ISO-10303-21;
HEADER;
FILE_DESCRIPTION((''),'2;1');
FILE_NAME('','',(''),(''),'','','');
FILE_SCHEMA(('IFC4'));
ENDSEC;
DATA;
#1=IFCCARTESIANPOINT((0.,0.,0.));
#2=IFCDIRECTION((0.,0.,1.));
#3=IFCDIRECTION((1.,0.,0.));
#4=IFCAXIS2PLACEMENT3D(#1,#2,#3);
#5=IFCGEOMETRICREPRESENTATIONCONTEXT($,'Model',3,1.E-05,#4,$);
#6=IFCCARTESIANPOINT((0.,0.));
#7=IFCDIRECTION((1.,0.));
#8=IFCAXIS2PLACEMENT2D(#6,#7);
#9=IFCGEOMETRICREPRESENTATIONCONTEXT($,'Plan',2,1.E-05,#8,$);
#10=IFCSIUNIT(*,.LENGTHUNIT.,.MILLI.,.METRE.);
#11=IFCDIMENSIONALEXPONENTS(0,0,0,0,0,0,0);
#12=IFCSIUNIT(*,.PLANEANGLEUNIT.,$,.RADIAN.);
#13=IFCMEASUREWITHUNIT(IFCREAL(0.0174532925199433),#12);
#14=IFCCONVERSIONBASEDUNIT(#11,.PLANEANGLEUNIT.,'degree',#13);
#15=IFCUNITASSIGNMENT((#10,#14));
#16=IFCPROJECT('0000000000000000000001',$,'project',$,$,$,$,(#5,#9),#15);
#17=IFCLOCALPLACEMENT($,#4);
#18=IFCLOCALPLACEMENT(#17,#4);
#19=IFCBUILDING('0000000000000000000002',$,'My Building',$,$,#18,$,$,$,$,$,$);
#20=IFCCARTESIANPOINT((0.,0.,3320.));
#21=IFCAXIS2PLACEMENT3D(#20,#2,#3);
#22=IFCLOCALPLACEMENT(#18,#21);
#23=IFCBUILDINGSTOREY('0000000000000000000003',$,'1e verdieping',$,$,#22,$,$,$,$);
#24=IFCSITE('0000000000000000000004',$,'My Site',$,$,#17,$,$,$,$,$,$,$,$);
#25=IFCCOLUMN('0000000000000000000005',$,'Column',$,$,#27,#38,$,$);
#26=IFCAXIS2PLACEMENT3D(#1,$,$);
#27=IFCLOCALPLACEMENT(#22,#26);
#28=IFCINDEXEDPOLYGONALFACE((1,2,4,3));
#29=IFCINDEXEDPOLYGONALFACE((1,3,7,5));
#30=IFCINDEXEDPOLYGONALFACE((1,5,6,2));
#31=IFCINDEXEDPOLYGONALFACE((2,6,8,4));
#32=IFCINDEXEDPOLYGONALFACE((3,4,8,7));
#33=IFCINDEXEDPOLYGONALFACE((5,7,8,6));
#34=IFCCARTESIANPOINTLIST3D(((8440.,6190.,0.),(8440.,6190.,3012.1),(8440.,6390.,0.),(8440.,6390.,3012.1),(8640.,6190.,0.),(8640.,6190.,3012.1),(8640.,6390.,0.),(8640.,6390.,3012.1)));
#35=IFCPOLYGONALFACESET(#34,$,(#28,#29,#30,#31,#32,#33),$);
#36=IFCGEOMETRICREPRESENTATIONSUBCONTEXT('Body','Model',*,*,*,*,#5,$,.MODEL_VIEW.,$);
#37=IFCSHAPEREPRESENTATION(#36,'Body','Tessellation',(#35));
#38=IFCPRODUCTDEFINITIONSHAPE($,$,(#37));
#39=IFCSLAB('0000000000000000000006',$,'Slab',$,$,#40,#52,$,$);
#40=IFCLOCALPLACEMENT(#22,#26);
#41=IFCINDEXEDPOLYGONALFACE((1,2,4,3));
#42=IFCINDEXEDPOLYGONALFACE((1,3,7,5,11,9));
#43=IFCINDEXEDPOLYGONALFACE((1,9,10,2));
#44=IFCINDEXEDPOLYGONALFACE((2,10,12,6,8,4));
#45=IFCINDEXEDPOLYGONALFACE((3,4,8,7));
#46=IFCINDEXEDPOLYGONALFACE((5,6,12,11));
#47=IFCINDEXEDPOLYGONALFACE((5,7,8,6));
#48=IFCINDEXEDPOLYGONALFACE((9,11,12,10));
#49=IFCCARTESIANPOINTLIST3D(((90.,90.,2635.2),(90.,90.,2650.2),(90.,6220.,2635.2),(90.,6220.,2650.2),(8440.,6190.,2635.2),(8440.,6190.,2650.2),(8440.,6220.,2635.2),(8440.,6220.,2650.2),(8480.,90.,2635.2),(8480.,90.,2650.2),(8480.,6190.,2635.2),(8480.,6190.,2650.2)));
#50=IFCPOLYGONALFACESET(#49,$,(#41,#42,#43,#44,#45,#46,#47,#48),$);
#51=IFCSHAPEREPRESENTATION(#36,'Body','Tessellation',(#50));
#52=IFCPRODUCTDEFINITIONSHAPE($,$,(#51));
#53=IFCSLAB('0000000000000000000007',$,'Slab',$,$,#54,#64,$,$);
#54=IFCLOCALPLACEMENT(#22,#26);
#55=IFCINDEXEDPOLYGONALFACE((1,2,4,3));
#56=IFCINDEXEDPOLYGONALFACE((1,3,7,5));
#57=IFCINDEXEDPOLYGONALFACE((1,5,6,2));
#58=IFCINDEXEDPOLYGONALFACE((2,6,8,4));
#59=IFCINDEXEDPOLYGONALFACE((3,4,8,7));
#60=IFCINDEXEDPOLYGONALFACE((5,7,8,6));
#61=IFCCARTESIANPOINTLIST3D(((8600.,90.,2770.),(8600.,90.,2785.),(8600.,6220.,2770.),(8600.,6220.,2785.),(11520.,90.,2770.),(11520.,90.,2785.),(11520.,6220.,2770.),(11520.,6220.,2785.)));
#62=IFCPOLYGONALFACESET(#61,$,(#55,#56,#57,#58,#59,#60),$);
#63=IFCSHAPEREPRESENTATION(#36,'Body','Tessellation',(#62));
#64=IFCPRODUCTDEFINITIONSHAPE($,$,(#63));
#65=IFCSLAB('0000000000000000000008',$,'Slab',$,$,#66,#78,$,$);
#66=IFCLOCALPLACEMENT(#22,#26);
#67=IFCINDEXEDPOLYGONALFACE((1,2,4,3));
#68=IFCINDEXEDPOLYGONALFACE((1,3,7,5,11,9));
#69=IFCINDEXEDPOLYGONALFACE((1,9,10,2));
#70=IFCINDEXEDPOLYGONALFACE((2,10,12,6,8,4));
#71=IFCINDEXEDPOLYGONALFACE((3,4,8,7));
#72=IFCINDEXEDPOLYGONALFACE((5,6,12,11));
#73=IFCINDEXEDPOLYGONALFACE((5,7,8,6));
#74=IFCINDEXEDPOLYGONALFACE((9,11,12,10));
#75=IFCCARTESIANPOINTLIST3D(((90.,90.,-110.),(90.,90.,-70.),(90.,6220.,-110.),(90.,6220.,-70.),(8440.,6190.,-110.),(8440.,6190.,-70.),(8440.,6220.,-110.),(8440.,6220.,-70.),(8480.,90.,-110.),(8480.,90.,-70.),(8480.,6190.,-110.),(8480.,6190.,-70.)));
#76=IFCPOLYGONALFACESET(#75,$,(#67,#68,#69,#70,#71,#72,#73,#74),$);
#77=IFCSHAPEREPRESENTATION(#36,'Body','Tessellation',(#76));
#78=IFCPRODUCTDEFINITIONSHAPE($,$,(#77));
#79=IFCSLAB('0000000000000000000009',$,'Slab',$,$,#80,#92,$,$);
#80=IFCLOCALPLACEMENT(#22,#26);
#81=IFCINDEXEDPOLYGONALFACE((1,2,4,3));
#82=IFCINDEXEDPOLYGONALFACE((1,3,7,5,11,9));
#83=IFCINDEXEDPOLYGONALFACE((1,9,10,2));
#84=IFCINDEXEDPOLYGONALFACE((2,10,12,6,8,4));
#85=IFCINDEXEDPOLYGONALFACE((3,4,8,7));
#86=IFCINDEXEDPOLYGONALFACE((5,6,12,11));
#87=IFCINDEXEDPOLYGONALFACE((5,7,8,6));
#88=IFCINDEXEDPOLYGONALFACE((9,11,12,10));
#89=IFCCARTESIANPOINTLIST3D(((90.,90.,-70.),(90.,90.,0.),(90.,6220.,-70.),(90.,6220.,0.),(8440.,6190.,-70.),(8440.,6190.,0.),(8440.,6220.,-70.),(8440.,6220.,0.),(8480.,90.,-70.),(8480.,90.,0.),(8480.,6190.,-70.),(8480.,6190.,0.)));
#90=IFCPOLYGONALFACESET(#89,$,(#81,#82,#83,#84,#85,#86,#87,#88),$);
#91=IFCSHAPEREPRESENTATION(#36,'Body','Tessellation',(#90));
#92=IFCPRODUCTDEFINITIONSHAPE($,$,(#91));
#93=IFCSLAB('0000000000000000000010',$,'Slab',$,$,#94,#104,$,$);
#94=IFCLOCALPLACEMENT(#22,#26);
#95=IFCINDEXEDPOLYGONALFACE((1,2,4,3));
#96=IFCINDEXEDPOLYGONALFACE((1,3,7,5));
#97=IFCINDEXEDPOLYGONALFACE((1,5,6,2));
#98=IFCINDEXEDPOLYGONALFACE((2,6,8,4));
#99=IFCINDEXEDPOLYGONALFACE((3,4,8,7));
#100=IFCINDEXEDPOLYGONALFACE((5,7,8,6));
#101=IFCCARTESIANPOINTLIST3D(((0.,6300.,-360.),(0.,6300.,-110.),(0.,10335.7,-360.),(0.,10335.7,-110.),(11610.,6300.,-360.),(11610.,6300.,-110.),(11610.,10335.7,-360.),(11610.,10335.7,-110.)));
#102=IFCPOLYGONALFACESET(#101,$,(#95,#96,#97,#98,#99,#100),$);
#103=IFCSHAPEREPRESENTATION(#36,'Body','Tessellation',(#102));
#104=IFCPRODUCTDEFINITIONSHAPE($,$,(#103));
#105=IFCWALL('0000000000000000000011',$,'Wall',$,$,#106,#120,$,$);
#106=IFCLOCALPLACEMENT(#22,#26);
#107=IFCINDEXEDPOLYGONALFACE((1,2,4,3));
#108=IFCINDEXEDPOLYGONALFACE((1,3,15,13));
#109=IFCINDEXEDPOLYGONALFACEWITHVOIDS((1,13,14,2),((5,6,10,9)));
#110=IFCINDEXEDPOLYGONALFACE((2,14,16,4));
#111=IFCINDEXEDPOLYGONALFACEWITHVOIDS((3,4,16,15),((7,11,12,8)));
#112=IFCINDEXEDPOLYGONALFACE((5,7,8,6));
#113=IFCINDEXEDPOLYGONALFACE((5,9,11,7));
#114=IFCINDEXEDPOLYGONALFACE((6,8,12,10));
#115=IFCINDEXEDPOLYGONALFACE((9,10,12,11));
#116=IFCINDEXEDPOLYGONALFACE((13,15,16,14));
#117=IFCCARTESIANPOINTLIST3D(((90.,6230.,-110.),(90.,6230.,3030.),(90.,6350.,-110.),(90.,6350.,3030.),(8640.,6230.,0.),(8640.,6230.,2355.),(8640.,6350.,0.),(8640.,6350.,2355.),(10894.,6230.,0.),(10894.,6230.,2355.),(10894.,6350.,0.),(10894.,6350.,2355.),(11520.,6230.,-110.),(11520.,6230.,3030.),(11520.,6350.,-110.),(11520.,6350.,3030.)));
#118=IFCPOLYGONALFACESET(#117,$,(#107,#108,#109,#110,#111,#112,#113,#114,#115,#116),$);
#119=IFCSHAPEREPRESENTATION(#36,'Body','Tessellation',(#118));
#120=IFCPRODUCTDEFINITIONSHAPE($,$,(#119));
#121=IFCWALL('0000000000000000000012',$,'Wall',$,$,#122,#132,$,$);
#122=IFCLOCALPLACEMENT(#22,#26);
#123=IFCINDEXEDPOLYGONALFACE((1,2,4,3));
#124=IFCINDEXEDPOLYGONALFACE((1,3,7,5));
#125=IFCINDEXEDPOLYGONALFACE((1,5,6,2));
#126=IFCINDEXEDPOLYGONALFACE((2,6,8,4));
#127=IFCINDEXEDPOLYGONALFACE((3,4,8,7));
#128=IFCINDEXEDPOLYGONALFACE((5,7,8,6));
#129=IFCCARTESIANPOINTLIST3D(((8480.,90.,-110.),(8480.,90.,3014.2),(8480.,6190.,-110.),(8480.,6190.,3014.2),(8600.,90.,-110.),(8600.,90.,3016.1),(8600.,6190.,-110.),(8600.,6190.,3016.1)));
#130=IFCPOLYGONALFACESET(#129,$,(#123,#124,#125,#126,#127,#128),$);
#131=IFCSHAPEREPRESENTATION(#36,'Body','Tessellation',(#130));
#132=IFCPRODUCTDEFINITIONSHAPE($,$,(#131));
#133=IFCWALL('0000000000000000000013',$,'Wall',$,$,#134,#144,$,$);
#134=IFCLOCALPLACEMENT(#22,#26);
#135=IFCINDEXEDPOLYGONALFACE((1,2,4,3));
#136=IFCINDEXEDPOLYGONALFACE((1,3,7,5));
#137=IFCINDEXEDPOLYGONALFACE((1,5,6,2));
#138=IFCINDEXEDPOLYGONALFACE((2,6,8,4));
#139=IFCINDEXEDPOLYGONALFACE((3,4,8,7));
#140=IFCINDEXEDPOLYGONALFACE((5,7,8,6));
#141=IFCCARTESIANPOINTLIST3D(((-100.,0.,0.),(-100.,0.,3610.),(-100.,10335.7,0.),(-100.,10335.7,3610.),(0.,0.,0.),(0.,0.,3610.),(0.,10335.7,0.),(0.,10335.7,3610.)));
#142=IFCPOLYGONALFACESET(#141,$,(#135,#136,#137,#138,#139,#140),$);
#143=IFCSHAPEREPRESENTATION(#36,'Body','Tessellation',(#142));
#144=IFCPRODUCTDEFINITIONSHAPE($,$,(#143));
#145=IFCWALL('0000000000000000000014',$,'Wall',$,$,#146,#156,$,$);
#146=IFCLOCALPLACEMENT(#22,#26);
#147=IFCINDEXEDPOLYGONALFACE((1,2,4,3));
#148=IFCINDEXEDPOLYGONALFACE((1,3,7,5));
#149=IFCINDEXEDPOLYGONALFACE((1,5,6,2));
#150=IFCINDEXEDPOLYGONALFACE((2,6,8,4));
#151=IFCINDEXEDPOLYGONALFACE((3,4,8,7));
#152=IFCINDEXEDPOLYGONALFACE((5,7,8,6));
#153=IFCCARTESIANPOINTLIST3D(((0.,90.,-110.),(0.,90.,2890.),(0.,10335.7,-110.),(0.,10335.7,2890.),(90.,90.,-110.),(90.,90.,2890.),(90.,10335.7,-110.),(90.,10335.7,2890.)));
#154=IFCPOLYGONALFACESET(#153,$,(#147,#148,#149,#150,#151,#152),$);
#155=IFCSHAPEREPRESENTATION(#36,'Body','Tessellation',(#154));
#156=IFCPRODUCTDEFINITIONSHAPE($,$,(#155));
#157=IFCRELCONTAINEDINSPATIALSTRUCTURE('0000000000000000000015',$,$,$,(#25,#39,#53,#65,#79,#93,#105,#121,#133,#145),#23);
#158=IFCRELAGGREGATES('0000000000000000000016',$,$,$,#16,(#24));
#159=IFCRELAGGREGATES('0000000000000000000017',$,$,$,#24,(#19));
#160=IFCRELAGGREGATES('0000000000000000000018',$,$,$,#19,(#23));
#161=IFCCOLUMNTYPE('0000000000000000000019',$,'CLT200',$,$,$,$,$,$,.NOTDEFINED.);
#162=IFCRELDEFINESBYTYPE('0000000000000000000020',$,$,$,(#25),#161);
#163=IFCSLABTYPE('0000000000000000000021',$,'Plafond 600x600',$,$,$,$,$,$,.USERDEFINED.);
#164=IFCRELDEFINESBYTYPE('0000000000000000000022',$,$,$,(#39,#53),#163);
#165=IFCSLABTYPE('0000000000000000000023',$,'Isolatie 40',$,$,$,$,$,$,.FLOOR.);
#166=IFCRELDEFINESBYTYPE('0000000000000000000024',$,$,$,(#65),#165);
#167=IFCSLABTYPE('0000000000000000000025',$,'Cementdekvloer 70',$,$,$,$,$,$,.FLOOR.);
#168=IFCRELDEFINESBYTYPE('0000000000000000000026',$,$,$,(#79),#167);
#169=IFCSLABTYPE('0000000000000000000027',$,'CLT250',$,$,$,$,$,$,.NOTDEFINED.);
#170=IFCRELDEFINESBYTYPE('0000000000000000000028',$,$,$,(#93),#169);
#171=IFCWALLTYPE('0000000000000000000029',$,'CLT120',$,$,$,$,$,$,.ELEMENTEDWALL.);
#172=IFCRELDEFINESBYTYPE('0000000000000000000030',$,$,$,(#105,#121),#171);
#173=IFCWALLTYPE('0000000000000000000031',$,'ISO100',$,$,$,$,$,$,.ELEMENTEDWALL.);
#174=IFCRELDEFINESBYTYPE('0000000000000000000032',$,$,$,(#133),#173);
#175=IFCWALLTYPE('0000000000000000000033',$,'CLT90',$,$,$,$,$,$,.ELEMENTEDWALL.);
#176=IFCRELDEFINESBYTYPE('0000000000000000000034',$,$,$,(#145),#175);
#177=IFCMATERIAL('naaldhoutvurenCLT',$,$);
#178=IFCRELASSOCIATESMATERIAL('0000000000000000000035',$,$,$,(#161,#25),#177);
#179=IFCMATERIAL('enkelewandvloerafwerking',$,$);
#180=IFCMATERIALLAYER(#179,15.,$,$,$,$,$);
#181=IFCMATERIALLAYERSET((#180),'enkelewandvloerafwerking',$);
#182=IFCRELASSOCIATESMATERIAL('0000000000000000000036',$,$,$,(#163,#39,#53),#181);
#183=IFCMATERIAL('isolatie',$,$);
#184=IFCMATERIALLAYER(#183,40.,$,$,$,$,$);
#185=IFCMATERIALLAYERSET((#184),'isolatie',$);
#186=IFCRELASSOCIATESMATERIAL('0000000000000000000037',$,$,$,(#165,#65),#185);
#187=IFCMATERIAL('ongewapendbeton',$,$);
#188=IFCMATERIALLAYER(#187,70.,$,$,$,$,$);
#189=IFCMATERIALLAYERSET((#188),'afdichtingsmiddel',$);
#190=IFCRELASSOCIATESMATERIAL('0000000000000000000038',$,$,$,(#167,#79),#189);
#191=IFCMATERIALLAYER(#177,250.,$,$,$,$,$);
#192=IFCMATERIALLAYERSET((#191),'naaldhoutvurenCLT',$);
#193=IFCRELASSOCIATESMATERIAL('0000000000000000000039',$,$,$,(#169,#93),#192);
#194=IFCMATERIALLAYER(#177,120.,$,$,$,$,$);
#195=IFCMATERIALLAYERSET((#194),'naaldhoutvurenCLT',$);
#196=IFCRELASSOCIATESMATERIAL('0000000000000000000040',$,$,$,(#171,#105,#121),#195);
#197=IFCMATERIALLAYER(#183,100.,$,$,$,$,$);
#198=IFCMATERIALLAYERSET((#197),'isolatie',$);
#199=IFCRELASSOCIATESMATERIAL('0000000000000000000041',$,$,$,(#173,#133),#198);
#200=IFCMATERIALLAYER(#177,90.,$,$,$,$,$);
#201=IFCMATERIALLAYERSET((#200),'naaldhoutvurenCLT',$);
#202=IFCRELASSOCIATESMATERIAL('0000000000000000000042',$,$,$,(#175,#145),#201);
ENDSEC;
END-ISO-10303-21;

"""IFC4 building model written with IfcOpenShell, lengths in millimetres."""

from ifc_helpers import new_model, entity, si_unit, converted_unit, frame, origin_with_axes, origin_2d_with_axis, place, context, subcontext, project, spatial, line, indexed_curve, rectangle, outline, extrude, clip, halfspace, source, transform, mapped, material, layer, layer_set, layer_usage, material_profile, profile_set, profile_usage, type_object, element, save


model = new_model("IFC4")

# Units and contexts
model_context = context("Model", 3, precision=1e-05, world=origin_with_axes())
plan_context = context("Plan", 2, precision=1e-05, world=origin_2d_with_axis())
body_context = subcontext(model_context, "Body", "Model", "MODEL_VIEW")
ifc_project = project(units=[si_unit("LENGTHUNIT", "METRE", prefix="MILLI"), converted_unit("PLANEANGLEUNIT", "degree", entity("IfcReal", 0.0174532925199433), si_unit("PLANEANGLEUNIT", "RADIAN"), dimensions=[0, 0, 0, 0, 0, 0, 0])], contexts=[model_context, plan_context])

# Site, building, storey
site_placement = place(None, origin_with_axes())
site = spatial("IfcSite", under=ifc_project, at=site_placement, Name="My Site")
building_placement = place(site_placement, origin_with_axes())
building = spatial("IfcBuilding", under=site, at=building_placement, Name="My Building")
storey_placement = place(building_placement, frame((0.0, 0.0, 3320.0), z_axis=(0.0, 0.0, 1.0), x_axis=(1.0, 0.0, 0.0)))
storey = spatial("IfcBuildingStorey", under=building, at=storey_placement, Name="1e verdieping")

# Column
ifc_material_1 = material(Name="naaldhoutvurenCLT")
ifc_material_profile = material_profile(ifc_material_1, rectangle(XDim=200.0, YDim=200.0))
ifc_profile_set = profile_set([ifc_material_profile], Name="naaldhoutvurenCLT")
ifc_profile_usage = profile_usage(ifc_profile_set, cardinal=5)
column_type = type_object("IfcColumnType", Name="CLT200", PredefinedType="NOTDEFINED", material=ifc_profile_set)
column_placement = place(storey_placement, frame((8540.0, 6290.0, 0.0), z_axis=(0.0, 0.0, 1.0), x_axis=(1.0, 0.0, 0.0)))
element("IfcColumn", 1, at=column_placement, inside=storey, type_object=column_type, material=ifc_profile_usage, Name="Column", context=body_context, shape_type="SweptSolid", body=[
    extrude(rectangle(XDim=200.0, YDim=200.0), origin_with_axes(), (0.0, 0.0, 1.0), 3012.1),
])

# Slabs
ifc_material_2 = material(Name="enkelewandvloerafwerking")
ifc_layer_1 = layer(ifc_material_2, 15.0)
ifc_layer_set_1 = layer_set([ifc_layer_1], Name="enkelewandvloerafwerking")
ifc_layer_usage_1 = layer_usage(ifc_layer_set_1, "AXIS3", "POSITIVE", 0.0)
slab_type_1 = type_object("IfcSlabType", Name="Plafond 600x600", PredefinedType="USERDEFINED", material=ifc_layer_set_1)
slab_1_placement = place(storey_placement, frame((90.0, 90.0, 2635.2), z_axis=(0.0, 0.0, 1.0), x_axis=(1.0, 0.0, 0.0)))
element("IfcSlab", 2, at=slab_1_placement, inside=storey, type_object=slab_type_1, material=ifc_layer_usage_1, Name="Slab", context=body_context, shape_type="SweptSolid", body=[
    extrude(outline(indexed_curve([(0.0, 0.0), (8390.0, 0.0), (8350.0, 6130.0), (0.0, 6130.0), (8350.0, 6100.0), (8390.0, 6100.0)], segments=[line(3, 5), line(5, 6), line(6, 2), line(2, 1), line(1, 4), line(4, 3)], self_intersect=False)), None, (0.0, 0.0, 1.0), 15.0),
])
ifc_layer_usage_2 = layer_usage(ifc_layer_set_1, "AXIS3", "POSITIVE", 0.0)
slab_2_placement = place(storey_placement, frame((8600.0, 6220.0, 2770.0), z_axis=(0.0, 0.0, 1.0), x_axis=(1.0, 0.0, 0.0)))
element("IfcSlab", 3, at=slab_2_placement, inside=storey, type_object=slab_type_1, material=ifc_layer_usage_2, Name="Slab", context=body_context, shape_type="SweptSolid", body=[
    extrude(outline(indexed_curve([(0.0, -6130.0), (2920.0, -6130.0), (2920.0, 0.0), (0.0, 0.0)], segments=[line(4, 1), line(1, 2), line(2, 3), line(3, 4)], self_intersect=False)), None, (0.0, 0.0, 1.0), 15.0),
])
ifc_material_3 = material(Name="isolatie")
ifc_layer_2 = layer(ifc_material_3, 40.0)
ifc_layer_set_2 = layer_set([ifc_layer_2], Name="isolatie")
slab_type_2 = type_object("IfcSlabType", Name="Isolatie 40", PredefinedType="FLOOR", material=ifc_layer_set_2)
ifc_layer_usage_3 = layer_usage(ifc_layer_set_2, "AXIS3", "POSITIVE", 0.0)
slab_3_placement = place(storey_placement, frame((90.0, 90.0, -110.0), z_axis=(0.0, 0.0, 1.0), x_axis=(1.0, 0.0, 0.0)))
element("IfcSlab", 4, at=slab_3_placement, inside=storey, type_object=slab_type_2, material=ifc_layer_usage_3, Name="Slab", context=body_context, shape_type="SweptSolid", body=[
    extrude(outline(indexed_curve([(0.0, 0.0), (8390.0, 0.0), (8350.0, 6130.0), (0.0, 6130.0), (8350.0, 6100.0), (8390.0, 6100.0)], segments=[line(2, 1), line(1, 4), line(4, 3), line(3, 5), line(5, 6), line(6, 2)], self_intersect=False)), None, (0.0, 0.0, 1.0), 40.0),
])
ifc_material_4 = material(Name="ongewapendbeton")
ifc_layer_3 = layer(ifc_material_4, 70.0)
ifc_layer_set_3 = layer_set([ifc_layer_3], Name="afdichtingsmiddel")
slab_type_3 = type_object("IfcSlabType", Name="Cementdekvloer 70", PredefinedType="FLOOR", material=ifc_layer_set_3)
ifc_layer_usage_4 = layer_usage(ifc_layer_set_3, "AXIS3", "POSITIVE", 0.0)
slab_4_placement = place(storey_placement, frame((90.0, 90.0, -70.0), z_axis=(0.0, 0.0, 1.0), x_axis=(1.0, 0.0, 0.0)))
element("IfcSlab", 5, at=slab_4_placement, inside=storey, type_object=slab_type_3, material=ifc_layer_usage_4, Name="Slab", context=body_context, shape_type="SweptSolid", body=[
    extrude(outline(indexed_curve([(0.0, 0.0), (8390.0, 0.0), (8350.0, 6130.0), (0.0, 6130.0), (8350.0, 6100.0), (8390.0, 6100.0)], segments=[line(2, 1), line(1, 4), line(4, 3), line(3, 5), line(5, 6), line(6, 2)], self_intersect=False)), None, (0.0, 0.0, 1.0), 70.0),
])
ifc_layer_4 = layer(ifc_material_1, 250.0)
ifc_layer_set_4 = layer_set([ifc_layer_4], Name="naaldhoutvurenCLT")
ifc_layer_usage_5 = layer_usage(ifc_layer_set_4, "AXIS3", "POSITIVE", 0.0)
slab_type_4 = type_object("IfcSlabType", Name="CLT250", PredefinedType="NOTDEFINED", material=ifc_layer_set_4)
slab_5_placement = place(storey_placement, frame((0.0, 6300.0, -360.0), z_axis=(0.0, 0.0, 1.0), x_axis=(1.0, 0.0, 0.0)))
element("IfcSlab", 6, at=slab_5_placement, inside=storey, type_object=slab_type_4, material=ifc_layer_usage_5, Name="Slab", context=body_context, shape_type="SweptSolid", body=[
    extrude(outline(indexed_curve([(11610.0, 0.0), (0.0, 0.0), (0.0, 4035.7), (11610.0, 4035.7)], segments=[line(4, 1), line(1, 2), line(2, 3), line(3, 4)], self_intersect=False)), None, (0.0, 0.0, 1.0), 250.0),
])

# Wall, opening
ifc_layer_5 = layer(ifc_material_1, 120.0)
ifc_layer_set_5 = layer_set([ifc_layer_5], Name="naaldhoutvurenCLT")
ifc_layer_usage_6 = layer_usage(ifc_layer_set_5, "AXIS2", "POSITIVE", 0.0)
wall_type_1 = type_object("IfcWallType", Name="CLT120", PredefinedType="ELEMENTEDWALL", material=ifc_layer_set_5)
wall_1_placement = place(storey_placement, frame((90.0, 6230.0, -110.0), z_axis=(0.0, 0.0, 1.0), x_axis=(1.0, -0.000001, 0.0)))
wall_1 = element("IfcWall", 7, at=wall_1_placement, inside=storey, type_object=wall_type_1, material=ifc_layer_usage_6, Name="Wall", context=body_context, shape_type="SweptSolid", body=[
    extrude(outline(indexed_curve([(0.0, 0.0), (0.0, 120.0), (11430.0, 120.0), (11430.0, 0.0), (0.0, 0.0)], self_intersect=False)), origin_with_axes(), (0.0, 0.0, 1.0), 3140.0),
])
shared_shape_1 = source(origin_with_axes(), body_context, "Body", "SweptSolid", [
    extrude(outline(indexed_curve([(0.0, 0.0), (2254.0, 0.0), (2254.0, 2355.0), (0.0, 2355.0)], segments=[line(1, 2, 3, 4, 1)])), frame((0.0, -600.0, 0.0), z_axis=(0.0, -1.0, 0.0), x_axis=(1.0, 0.0, 0.0)), (0.0, 0.0, -1.0), 1200.0),
])
opening_1_placement = place(wall_1_placement, frame((8550.0, 31.8, 110.0), z_axis=(0.0, 0.0, 1.0), x_axis=(1.0, 0.0, 0.0)))
element("IfcOpeningElement", 8, at=opening_1_placement, cuts=wall_1, PredefinedType="OPENING", context=body_context, shape_type="MappedRepresentation", body=[
    mapped(shared_shape_1, transform((0.0, 0.0, 0.0), x_axis=(1.0, 0.0, 0.0), y_axis=(0.0, 1.0, 0.0), z_axis=(0.0, 0.0, 1.0), scale=1.0)),
])

# Walls
ifc_layer_usage_7 = layer_usage(ifc_layer_set_5, "AXIS2", "POSITIVE", 0.0)
wall_2_placement = place(storey_placement, frame((8600.0, 90.0, -110.0), z_axis=(0.0, 0.0, 1.0), x_axis=(0.0, 1.0, 0.0)))
element("IfcWall", 9, at=wall_2_placement, inside=storey, type_object=wall_type_1, material=ifc_layer_usage_7, Name="Wall", context=body_context, shape_type="Clipping", body=[
    clip(extrude(outline(indexed_curve([(0.0, 0.0), (0.0, 120.0), (6100.0, 120.0), (6100.0, 0.0), (0.0, 0.0)], self_intersect=False)), origin_with_axes(), (0.0, 0.0, 1.0), 6336.1), halfspace(frame((0.0, 0.0, 3126.1), z_axis=(0.0, 0.016405, 0.999865), x_axis=(1.0, 0.0, 0.0)), False)),
])
ifc_layer_6 = layer(ifc_material_3, 100.0)
ifc_layer_set_6 = layer_set([ifc_layer_6], Name="isolatie")
ifc_layer_usage_8 = layer_usage(ifc_layer_set_6, "AXIS2", "POSITIVE", 0.0)
wall_type_2 = type_object("IfcWallType", Name="ISO100", PredefinedType="ELEMENTEDWALL", material=ifc_layer_set_6)
wall_3_placement = place(storey_placement, frame((0.0, 0.0, 0.0), z_axis=(0.0, 0.0, 1.0), x_axis=(0.0, 1.0, 0.0)))
element("IfcWall", 10, at=wall_3_placement, inside=storey, type_object=wall_type_2, material=ifc_layer_usage_8, Name="Wall", context=body_context, shape_type="SweptSolid", body=[
    extrude(outline(indexed_curve([(0.0, 0.0), (0.0, 100.0), (10335.7, 100.0), (10335.7, 0.0), (0.0, 0.0)], self_intersect=False)), origin_with_axes(), (0.0, 0.0, 1.0), 3610.0),
])
ifc_layer_7 = layer(ifc_material_1, 90.0)
ifc_layer_set_7 = layer_set([ifc_layer_7], Name="naaldhoutvurenCLT")
ifc_layer_usage_9 = layer_usage(ifc_layer_set_7, "AXIS2", "POSITIVE", 0.0)
wall_type_3 = type_object("IfcWallType", Name="CLT90", PredefinedType="ELEMENTEDWALL", material=ifc_layer_set_7)
wall_4_placement = place(storey_placement, frame((90.0, 90.0, -110.0), z_axis=(0.0, 0.0, 1.0), x_axis=(0.0, 1.0, 0.0)))
element("IfcWall", 11, at=wall_4_placement, inside=storey, type_object=wall_type_3, material=ifc_layer_usage_9, Name="Wall", context=body_context, shape_type="SweptSolid", body=[
    extrude(outline(indexed_curve([(0.0, 0.0), (0.0, 90.0), (10245.7, 90.0), (10245.7, 0.0), (0.0, 0.0)], self_intersect=False)), origin_with_axes(), (0.0, 0.0, 1.0), 3000.0),
])

save(model, "model.ifc")
